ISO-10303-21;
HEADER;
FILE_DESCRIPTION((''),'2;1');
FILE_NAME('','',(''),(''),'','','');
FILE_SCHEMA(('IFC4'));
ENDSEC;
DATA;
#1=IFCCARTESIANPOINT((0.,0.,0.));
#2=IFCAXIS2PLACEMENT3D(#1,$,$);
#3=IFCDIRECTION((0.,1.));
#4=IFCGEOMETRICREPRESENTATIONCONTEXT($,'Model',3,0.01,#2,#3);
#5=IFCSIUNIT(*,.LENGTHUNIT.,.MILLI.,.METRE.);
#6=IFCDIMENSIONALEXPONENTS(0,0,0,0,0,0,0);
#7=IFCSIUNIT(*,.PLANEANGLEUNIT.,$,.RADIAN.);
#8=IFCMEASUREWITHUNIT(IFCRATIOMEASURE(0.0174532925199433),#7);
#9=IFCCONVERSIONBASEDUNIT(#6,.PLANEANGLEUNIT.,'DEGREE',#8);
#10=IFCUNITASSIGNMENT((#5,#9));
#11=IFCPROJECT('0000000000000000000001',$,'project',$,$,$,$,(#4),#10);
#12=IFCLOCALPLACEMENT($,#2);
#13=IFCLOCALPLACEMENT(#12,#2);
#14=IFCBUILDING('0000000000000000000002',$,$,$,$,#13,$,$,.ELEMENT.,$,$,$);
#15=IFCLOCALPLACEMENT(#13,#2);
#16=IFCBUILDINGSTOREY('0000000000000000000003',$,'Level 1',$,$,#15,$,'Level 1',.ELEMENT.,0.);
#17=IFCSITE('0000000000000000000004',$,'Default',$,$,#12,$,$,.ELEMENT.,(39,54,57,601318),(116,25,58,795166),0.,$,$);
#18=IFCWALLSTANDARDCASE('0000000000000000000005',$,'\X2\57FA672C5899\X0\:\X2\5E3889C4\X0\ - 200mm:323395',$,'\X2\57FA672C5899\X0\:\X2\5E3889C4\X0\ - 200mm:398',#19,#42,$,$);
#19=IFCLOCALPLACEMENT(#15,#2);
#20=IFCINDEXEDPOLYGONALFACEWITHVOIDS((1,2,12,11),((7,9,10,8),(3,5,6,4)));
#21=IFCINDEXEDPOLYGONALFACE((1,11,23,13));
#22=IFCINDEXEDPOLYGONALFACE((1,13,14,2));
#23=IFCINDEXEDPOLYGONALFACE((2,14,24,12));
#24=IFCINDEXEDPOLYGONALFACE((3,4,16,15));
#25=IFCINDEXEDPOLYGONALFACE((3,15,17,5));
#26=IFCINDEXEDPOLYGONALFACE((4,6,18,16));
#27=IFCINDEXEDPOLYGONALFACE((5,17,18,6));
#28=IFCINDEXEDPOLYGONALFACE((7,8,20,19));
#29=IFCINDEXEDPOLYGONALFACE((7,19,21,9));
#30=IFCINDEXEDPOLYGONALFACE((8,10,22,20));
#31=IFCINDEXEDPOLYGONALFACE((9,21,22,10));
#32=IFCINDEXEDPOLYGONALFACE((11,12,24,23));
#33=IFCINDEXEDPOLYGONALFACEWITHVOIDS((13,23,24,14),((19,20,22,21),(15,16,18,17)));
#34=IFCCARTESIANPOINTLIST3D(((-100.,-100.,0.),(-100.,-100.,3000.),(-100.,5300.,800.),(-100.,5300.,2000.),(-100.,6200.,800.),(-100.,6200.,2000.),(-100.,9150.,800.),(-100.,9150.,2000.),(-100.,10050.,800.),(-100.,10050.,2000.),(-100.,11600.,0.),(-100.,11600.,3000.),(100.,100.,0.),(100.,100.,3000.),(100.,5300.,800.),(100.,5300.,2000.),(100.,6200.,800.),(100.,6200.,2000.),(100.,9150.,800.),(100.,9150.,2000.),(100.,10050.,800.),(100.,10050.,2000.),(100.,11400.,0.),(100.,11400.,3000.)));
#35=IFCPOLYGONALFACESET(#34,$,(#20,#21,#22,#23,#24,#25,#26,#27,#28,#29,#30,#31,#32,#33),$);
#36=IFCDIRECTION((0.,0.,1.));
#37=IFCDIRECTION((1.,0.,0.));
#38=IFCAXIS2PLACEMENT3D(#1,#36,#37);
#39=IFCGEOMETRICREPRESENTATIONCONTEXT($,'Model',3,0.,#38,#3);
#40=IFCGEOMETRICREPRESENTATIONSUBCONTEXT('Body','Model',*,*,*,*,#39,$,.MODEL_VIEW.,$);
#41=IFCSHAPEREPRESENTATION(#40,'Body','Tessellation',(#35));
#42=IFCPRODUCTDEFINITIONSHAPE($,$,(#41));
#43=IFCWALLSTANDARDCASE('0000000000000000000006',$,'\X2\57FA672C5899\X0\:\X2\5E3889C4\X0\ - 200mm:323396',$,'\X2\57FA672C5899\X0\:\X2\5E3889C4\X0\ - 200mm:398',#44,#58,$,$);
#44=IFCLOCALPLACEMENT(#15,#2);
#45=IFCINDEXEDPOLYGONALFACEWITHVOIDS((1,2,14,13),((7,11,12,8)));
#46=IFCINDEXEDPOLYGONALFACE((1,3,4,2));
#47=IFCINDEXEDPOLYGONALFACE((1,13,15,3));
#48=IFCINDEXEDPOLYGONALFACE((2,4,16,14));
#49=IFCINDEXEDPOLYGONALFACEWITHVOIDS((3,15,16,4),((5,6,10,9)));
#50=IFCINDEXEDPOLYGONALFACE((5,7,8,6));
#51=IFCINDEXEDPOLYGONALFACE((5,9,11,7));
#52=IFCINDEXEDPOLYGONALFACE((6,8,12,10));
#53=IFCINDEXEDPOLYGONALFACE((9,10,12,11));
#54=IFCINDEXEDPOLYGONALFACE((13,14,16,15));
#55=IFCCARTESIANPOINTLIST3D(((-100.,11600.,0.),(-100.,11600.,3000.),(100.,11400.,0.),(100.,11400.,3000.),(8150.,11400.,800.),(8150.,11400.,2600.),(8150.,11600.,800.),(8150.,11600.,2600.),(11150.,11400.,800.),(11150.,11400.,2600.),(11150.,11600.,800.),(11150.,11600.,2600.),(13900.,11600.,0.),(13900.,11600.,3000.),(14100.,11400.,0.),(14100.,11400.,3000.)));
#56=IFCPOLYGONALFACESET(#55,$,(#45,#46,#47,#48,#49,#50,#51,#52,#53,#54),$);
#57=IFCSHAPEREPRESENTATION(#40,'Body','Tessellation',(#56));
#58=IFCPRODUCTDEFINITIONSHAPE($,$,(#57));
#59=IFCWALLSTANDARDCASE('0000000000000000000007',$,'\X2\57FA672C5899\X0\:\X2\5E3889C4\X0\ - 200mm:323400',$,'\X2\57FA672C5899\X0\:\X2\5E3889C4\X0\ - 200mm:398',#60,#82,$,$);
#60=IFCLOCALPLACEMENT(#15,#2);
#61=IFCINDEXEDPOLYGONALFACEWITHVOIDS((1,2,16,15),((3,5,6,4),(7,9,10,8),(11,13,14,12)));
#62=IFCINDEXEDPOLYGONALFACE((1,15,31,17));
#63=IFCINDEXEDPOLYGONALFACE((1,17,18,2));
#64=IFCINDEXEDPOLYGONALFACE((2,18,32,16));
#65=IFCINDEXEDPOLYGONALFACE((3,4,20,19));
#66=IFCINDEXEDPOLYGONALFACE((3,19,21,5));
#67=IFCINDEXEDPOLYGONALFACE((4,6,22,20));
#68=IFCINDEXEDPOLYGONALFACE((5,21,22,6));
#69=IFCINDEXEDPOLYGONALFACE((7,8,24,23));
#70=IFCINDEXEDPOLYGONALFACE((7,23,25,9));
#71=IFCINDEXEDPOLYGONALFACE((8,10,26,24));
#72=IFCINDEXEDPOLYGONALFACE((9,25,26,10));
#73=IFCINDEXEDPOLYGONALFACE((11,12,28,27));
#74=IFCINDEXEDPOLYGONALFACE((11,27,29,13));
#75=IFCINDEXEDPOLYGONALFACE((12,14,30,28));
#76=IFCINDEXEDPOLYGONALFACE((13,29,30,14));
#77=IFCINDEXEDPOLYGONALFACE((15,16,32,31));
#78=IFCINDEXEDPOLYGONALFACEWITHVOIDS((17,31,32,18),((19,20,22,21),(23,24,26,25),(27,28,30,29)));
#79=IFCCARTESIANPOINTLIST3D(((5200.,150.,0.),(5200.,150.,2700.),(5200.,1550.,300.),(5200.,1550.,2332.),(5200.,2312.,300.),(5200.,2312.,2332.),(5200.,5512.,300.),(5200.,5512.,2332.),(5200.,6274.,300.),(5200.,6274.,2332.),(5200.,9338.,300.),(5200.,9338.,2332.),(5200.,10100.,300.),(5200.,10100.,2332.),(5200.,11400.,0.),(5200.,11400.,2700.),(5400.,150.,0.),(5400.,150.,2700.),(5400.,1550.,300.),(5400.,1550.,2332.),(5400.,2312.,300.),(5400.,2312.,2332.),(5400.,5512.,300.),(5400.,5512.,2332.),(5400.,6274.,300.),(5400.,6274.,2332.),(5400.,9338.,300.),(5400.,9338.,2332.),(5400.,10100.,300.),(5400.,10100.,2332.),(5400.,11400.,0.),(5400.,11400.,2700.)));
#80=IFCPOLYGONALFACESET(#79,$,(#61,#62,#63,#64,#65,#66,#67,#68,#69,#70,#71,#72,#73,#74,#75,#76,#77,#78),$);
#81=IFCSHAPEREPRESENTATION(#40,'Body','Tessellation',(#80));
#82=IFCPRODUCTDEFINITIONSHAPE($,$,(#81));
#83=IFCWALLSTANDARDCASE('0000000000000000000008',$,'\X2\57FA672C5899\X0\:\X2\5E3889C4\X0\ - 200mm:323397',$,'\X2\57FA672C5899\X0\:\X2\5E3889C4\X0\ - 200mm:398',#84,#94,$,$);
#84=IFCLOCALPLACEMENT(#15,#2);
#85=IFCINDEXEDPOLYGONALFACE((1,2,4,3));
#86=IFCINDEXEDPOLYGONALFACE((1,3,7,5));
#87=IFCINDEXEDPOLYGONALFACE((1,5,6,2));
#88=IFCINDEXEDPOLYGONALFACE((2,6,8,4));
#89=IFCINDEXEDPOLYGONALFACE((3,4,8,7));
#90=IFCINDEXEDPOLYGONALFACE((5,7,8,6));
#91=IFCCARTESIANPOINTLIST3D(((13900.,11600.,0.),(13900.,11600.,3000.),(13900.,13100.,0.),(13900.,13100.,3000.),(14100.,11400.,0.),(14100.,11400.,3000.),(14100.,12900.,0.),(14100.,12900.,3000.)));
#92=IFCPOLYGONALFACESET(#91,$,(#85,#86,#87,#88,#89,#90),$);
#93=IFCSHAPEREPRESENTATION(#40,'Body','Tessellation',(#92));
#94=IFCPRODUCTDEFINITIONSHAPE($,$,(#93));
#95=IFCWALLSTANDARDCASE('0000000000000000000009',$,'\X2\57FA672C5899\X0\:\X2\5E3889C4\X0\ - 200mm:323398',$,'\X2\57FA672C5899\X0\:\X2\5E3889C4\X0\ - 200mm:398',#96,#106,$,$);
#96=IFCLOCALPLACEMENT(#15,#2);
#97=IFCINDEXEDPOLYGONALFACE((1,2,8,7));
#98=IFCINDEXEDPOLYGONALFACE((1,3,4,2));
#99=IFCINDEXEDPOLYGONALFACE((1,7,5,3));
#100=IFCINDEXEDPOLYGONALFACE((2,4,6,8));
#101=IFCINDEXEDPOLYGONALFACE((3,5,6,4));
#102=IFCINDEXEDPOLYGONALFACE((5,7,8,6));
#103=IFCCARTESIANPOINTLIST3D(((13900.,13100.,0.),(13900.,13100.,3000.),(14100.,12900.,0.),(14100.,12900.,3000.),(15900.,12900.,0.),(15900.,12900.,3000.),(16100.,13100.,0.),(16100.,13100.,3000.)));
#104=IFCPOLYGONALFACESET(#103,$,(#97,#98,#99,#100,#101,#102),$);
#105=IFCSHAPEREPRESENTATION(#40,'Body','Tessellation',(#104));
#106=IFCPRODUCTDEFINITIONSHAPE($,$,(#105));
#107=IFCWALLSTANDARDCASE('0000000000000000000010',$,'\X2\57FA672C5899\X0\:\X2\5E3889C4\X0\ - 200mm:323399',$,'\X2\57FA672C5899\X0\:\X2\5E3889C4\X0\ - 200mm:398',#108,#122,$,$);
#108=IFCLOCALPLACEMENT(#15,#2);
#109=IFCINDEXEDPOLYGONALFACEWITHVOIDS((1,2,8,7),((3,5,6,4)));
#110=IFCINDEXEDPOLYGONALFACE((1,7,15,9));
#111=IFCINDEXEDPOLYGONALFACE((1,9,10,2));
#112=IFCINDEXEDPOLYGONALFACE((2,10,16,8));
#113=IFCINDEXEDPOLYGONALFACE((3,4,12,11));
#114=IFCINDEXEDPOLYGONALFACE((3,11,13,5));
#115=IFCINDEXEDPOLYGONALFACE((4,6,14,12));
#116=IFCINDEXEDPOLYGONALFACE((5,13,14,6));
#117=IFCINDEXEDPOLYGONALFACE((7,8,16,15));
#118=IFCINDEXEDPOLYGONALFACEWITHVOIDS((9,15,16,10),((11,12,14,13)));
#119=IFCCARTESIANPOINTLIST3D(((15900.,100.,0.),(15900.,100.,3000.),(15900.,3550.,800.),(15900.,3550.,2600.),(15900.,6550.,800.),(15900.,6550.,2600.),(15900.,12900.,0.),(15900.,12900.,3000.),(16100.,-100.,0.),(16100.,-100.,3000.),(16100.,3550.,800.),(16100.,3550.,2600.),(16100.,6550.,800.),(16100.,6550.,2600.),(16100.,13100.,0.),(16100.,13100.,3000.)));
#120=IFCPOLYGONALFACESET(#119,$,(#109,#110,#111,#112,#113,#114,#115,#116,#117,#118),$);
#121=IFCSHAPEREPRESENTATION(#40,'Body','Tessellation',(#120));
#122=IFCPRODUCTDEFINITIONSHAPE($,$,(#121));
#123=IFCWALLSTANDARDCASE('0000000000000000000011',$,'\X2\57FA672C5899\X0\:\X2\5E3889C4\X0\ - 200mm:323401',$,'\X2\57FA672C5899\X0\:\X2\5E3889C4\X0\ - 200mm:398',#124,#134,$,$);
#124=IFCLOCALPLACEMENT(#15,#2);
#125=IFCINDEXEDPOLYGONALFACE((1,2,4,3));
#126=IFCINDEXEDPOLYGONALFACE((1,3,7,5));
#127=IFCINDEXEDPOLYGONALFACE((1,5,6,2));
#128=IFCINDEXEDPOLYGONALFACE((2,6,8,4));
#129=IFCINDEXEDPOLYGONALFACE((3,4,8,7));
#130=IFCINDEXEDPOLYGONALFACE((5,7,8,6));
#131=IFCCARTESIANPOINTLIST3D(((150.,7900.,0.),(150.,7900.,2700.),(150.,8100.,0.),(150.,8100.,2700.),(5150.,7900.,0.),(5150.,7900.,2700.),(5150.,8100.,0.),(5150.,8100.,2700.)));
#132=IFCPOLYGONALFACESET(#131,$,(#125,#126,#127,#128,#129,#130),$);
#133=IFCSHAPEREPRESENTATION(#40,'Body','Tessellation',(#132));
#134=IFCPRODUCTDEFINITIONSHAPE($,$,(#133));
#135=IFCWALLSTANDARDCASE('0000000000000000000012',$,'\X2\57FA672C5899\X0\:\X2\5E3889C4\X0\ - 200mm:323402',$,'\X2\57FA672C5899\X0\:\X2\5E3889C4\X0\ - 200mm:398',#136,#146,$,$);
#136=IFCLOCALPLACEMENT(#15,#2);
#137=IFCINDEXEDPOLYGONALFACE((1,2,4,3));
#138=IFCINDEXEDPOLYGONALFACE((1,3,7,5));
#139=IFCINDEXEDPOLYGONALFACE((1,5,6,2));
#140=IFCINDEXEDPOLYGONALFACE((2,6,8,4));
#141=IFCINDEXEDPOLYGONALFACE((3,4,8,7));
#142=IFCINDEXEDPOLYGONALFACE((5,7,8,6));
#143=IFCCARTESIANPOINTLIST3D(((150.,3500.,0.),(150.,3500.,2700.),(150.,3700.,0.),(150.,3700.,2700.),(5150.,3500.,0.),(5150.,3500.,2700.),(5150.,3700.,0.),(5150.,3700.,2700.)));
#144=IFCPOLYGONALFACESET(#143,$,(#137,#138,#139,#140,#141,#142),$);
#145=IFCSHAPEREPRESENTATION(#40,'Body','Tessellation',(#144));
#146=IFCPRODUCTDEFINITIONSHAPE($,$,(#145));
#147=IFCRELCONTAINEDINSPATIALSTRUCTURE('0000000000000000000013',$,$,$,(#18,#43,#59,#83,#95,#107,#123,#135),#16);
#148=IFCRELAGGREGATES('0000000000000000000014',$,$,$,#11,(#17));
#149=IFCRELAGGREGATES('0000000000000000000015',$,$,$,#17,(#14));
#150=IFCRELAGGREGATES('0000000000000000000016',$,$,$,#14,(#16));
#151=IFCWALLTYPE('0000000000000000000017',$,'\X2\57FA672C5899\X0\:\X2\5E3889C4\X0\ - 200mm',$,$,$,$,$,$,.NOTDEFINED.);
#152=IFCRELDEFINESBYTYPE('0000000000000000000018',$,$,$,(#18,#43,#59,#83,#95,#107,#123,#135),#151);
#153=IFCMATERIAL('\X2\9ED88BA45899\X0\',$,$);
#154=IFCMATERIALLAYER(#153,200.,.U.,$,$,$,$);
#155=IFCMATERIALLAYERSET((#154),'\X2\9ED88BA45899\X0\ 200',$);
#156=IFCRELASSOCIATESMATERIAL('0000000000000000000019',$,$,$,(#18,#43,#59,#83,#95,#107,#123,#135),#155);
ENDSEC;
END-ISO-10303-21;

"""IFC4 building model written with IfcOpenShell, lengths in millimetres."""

from ifc_helpers import new_model, entity, si_unit, converted_unit, direction, frame, origin, origin_with_axes, place, context, subcontext, project, spatial, polyline, outline, extrude, clip, halfspace, material, layer, layer_set, layer_usage, type_object, element, save


model = new_model("IFC4")

# Units and contexts
model_context_1 = context("Model", 3, precision=0.01, world=origin(), true_north=direction((0.0, 1.0)))
model_context_2 = context("Model", 3, precision=0.0, world=origin_with_axes(), true_north=direction((0.0, 1.0)))
body_context_1 = subcontext(model_context_2, "Body", "Model", "MODEL_VIEW")
ifc_project = project(units=[si_unit("LENGTHUNIT", "METRE", prefix="MILLI"), converted_unit("PLANEANGLEUNIT", "DEGREE", entity("IfcRatioMeasure", 0.0174532925199433), si_unit("PLANEANGLEUNIT", "RADIAN"), dimensions=[0, 0, 0, 0, 0, 0, 0])], contexts=[model_context_1])

# Site, building, storey
site_placement = place(None, origin())
site = spatial("IfcSite", under=ifc_project, at=site_placement, Name="Default", CompositionType="ELEMENT", RefLatitude=(39, 54, 57, 601318), RefLongitude=(116, 25, 58, 795166), RefElevation=0.0)
building_placement = place(site_placement, origin())
building = spatial("IfcBuilding", under=site, at=building_placement, CompositionType="ELEMENT")
storey_placement = place(building_placement, origin())
storey = spatial("IfcBuildingStorey", under=building, at=storey_placement, Name="Level 1", LongName="Level 1", CompositionType="ELEMENT", Elevation=0.0)

# Shared definitions
placement_1 = place(None, origin_with_axes())
placement_2 = place(placement_1, origin_with_axes())
placement_3 = place(placement_2, origin_with_axes())

# Wall, openings
ifc_material_1 = material(Name="默认墙")
ifc_layer_1 = layer(ifc_material_1, 200.0, ventilated="UNKNOWN")
ifc_layer_set_1 = layer_set([ifc_layer_1], Name="默认墙 200")
wall_type = type_object("IfcWallType", Name="基本墙:常规 - 200mm", PredefinedType="NOTDEFINED")
ifc_layer_usage_1 = layer_usage(ifc_layer_set_1, "AXIS2", "POSITIVE", -100.0)
wall_1_placement = place(placement_3, frame((0.0, 0.0, 0.0), z_axis=(0.0, 0.0, 1.0), x_axis=(0.0, 1.0, 0.0)))
wall_1 = element("IfcWallStandardCase", 1, at=wall_1_placement, inside=storey, type_object=wall_type, material=ifc_layer_usage_1, Name="基本墙:常规 - 200mm:323395", ObjectType="基本墙:常规 - 200mm:398", context=body_context_1, shape_type="SweptSolid", body=[
    extrude(outline(polyline([(100.0, -100.0), (11400.0, -100.0), (11600.0, 100.0), (-100.0, 100.0), (100.0, -100.0)])), origin_with_axes(), (0.0, 0.0, 1.0), 3000.0),
])
opening_1_placement = place(wall_1_placement, frame((5750.0, 0.0, 800.0), z_axis=(0.0, 0.0, 1.0), x_axis=(1.0, 0.0, 0.0)))
element("IfcOpeningElement", 2, at=opening_1_placement, cuts=wall_1, context=body_context_1, shape_type="SweptSolid", body=[
    extrude(outline(polyline([(450.0, -1200.0), (450.0, 0.0), (-450.0, 0.0), (-450.0, -1200.0), (450.0, -1200.0)])), frame((0.0, 100.0, 0.0), z_axis=(0.0, -1.0, 0.0), x_axis=(-1.0, 0.0, 0.0)), (0.0, 0.0, 1.0), 200.0),
])
opening_2_placement = place(wall_1_placement, frame((9600.0, 0.0, 800.0), z_axis=(0.0, 0.0, 1.0), x_axis=(1.0, 0.0, 0.0)))
element("IfcOpeningElement", 3, at=opening_2_placement, cuts=wall_1, context=body_context_1, shape_type="SweptSolid", body=[
    extrude(outline(polyline([(450.0, -1200.0), (450.0, 0.0), (-450.0, 0.0), (-450.0, -1200.0), (450.0, -1200.0)])), frame((0.0, 100.0, 0.0), z_axis=(0.0, -1.0, 0.0), x_axis=(-1.0, 0.0, 0.0)), (0.0, 0.0, 1.0), 200.0),
])

# Wall, opening
ifc_layer_usage_2 = layer_usage(ifc_layer_set_1, "AXIS2", "POSITIVE", -100.0)
wall_2_placement = place(placement_3, frame((0.0, 11500.0, 0.0), z_axis=(0.0, 0.0, 1.0), x_axis=(1.0, 0.0, 0.0)))
wall_2 = element("IfcWallStandardCase", 4, at=wall_2_placement, inside=storey, type_object=wall_type, material=ifc_layer_usage_2, Name="基本墙:常规 - 200mm:323396", ObjectType="基本墙:常规 - 200mm:398", context=body_context_1, shape_type="SweptSolid", body=[
    extrude(outline(polyline([(100.0, -100.0), (14100.0, -100.0), (13900.0, 100.0), (-100.0, 100.0), (100.0, -100.0)])), origin_with_axes(), (0.0, 0.0, 1.0), 3000.0),
])
opening_3_placement = place(wall_2_placement, frame((9650.0, 0.0, 800.0), z_axis=(0.0, 0.0, 1.0), x_axis=(1.0, 0.0, 0.0)))
element("IfcOpeningElement", 5, at=opening_3_placement, cuts=wall_2, context=body_context_1, shape_type="SweptSolid", body=[
    extrude(outline(polyline([(-1500.0, 0.0), (-1500.0, -1800.0), (1500.0, -1800.0), (1500.0, 0.0), (-1500.0, 0.0)])), frame((0.0, -100.0, 0.0), z_axis=(0.0, 1.0, 0.0), x_axis=(1.0, 0.0, 0.0)), (0.0, 0.0, 1.0), 200.0),
])

# Wall, openings
ifc_layer_usage_3 = layer_usage(ifc_layer_set_1, "AXIS2", "POSITIVE", -100.0)
wall_3_placement = place(placement_3, frame((5300.0, 11500.0, 0.0), z_axis=(0.0, 0.0, 1.0), x_axis=(0.0, -1.0, 0.0)))
wall_3 = element("IfcWallStandardCase", 6, at=wall_3_placement, inside=storey, type_object=wall_type, material=ifc_layer_usage_3, Name="基本墙:常规 - 200mm:323400", ObjectType="基本墙:常规 - 200mm:398", context=body_context_1, shape_type="Clipping", body=[
    clip(extrude(outline(polyline([(100.0, -100.0), (11350.0, -100.0), (11350.0, 100.0), (100.0, 100.0), (100.0, -100.0)])), origin_with_axes(), (0.0, 0.0, 1.0), 2700.0), halfspace(frame((0.0, 0.0, 2700.0), z_axis=(0.0, 0.0, -1.0), x_axis=(0.0, 1.0, 0.0)), True)),
])
opening_4_placement = place(wall_3_placement, frame((9569.0, 0.0, 300.0), z_axis=(0.0, 0.0, 1.0), x_axis=(1.0, 0.0, 0.0)))
element("IfcOpeningElement", 7, at=opening_4_placement, cuts=wall_3, context=body_context_1, shape_type="SweptSolid", body=[
    extrude(outline(polyline([(-381.0, -2032.0), (381.0, -2032.0), (381.0, 0.0), (-381.0, 0.0), (-381.0, -2032.0)])), frame((0.0, -100.0, 0.0), z_axis=(0.0, 1.0, 0.0), x_axis=(1.0, 0.0, 0.0)), (0.0, 0.0, 1.0), 200.0),
])
opening_5_placement = place(wall_3_placement, frame((5607.0, 0.0, 300.0), z_axis=(0.0, 0.0, 1.0), x_axis=(1.0, 0.0, 0.0)))
element("IfcOpeningElement", 8, at=opening_5_placement, cuts=wall_3, context=body_context_1, shape_type="SweptSolid", body=[
    extrude(outline(polyline([(-381.0, -2032.0), (381.0, -2032.0), (381.0, 0.0), (-381.0, 0.0), (-381.0, -2032.0)])), frame((0.0, -100.0, 0.0), z_axis=(0.0, 1.0, 0.0), x_axis=(1.0, 0.0, 0.0)), (0.0, 0.0, 1.0), 200.0),
])
opening_6_placement = place(wall_3_placement, frame((1781.0, 0.0, 300.0), z_axis=(0.0, 0.0, 1.0), x_axis=(1.0, 0.0, 0.0)))
element("IfcOpeningElement", 9, at=opening_6_placement, cuts=wall_3, context=body_context_1, shape_type="SweptSolid", body=[
    extrude(outline(polyline([(-381.0, -2032.0), (381.0, -2032.0), (381.0, 0.0), (-381.0, 0.0), (-381.0, -2032.0)])), frame((0.0, -100.0, 0.0), z_axis=(0.0, 1.0, 0.0), x_axis=(1.0, 0.0, 0.0)), (0.0, 0.0, 1.0), 200.0),
])

# Walls
ifc_layer_usage_4 = layer_usage(ifc_layer_set_1, "AXIS2", "POSITIVE", -100.0)
wall_4_placement = place(placement_3, frame((14000.0, 11500.0, 0.0), z_axis=(0.0, 0.0, 1.0), x_axis=(0.0, 1.0, 0.0)))
element("IfcWallStandardCase", 10, at=wall_4_placement, inside=storey, type_object=wall_type, material=ifc_layer_usage_4, Name="基本墙:常规 - 200mm:323397", ObjectType="基本墙:常规 - 200mm:398", context=body_context_1, shape_type="SweptSolid", body=[
    extrude(outline(polyline([(-100.0, -100.0), (1400.0, -100.0), (1600.0, 100.0), (100.0, 100.0), (-100.0, -100.0)])), origin_with_axes(), (0.0, 0.0, 1.0), 3000.0),
])
ifc_layer_usage_5 = layer_usage(ifc_layer_set_1, "AXIS2", "POSITIVE", -100.0)
wall_5_placement = place(placement_3, frame((14000.0, 13000.0, 0.0), z_axis=(0.0, 0.0, 1.0), x_axis=(1.0, 0.0, 0.0)))
element("IfcWallStandardCase", 11, at=wall_5_placement, inside=storey, type_object=wall_type, material=ifc_layer_usage_5, Name="基本墙:常规 - 200mm:323398", ObjectType="基本墙:常规 - 200mm:398", context=body_context_1, shape_type="SweptSolid", body=[
    extrude(outline(polyline([(100.0, -100.0), (1900.0, -100.0), (2100.0, 100.0), (-100.0, 100.0), (100.0, -100.0)])), origin_with_axes(), (0.0, 0.0, 1.0), 3000.0),
])

# Wall, opening
ifc_layer_usage_6 = layer_usage(ifc_layer_set_1, "AXIS2", "POSITIVE", -100.0)
wall_6_placement = place(placement_3, frame((16000.0, 13000.0, 0.0), z_axis=(0.0, 0.0, 1.0), x_axis=(0.0, -1.0, 0.0)))
wall_6 = element("IfcWallStandardCase", 12, at=wall_6_placement, inside=storey, type_object=wall_type, material=ifc_layer_usage_6, Name="基本墙:常规 - 200mm:323399", ObjectType="基本墙:常规 - 200mm:398", context=body_context_1, shape_type="SweptSolid", body=[
    extrude(outline(polyline([(100.0, -100.0), (12900.0, -100.0), (13100.0, 100.0), (-100.0, 100.0), (100.0, -100.0)])), origin_with_axes(), (0.0, 0.0, 1.0), 3000.0),
])
opening_7_placement = place(wall_6_placement, frame((7950.0, 0.0, 800.0), z_axis=(0.0, 0.0, 1.0), x_axis=(1.0, 0.0, 0.0)))
element("IfcOpeningElement", 13, at=opening_7_placement, cuts=wall_6, context=body_context_1, shape_type="SweptSolid", body=[
    extrude(outline(polyline([(-1500.0, 0.0), (-1500.0, -1800.0), (1500.0, -1800.0), (1500.0, 0.0), (-1500.0, 0.0)])), frame((0.0, -100.0, 0.0), z_axis=(0.0, 1.0, 0.0), x_axis=(1.0, 0.0, 0.0)), (0.0, 0.0, 1.0), 200.0),
])

# Walls
ifc_layer_usage_7 = layer_usage(ifc_layer_set_1, "AXIS2", "POSITIVE", -100.0)
wall_7_placement = place(placement_3, frame((150.0, 8000.0, 0.0), z_axis=(0.0, 0.0, 1.0), x_axis=(1.0, 0.0, 0.0)))
element("IfcWallStandardCase", 14, at=wall_7_placement, inside=storey, type_object=wall_type, material=ifc_layer_usage_7, Name="基本墙:常规 - 200mm:323401", ObjectType="基本墙:常规 - 200mm:398", context=body_context_1, shape_type="Clipping", body=[
    clip(extrude(outline(polyline([(0.0, -100.0), (5000.0, -100.0), (5000.0, 100.0), (0.0, 100.0), (0.0, -100.0)])), origin_with_axes(), (0.0, 0.0, 1.0), 2700.0), halfspace(frame((0.0, 0.0, 2700.0), z_axis=(0.0, 0.0, -1.0), x_axis=(0.0, 1.0, 0.0)), True)),
])
ifc_layer_usage_8 = layer_usage(ifc_layer_set_1, "AXIS2", "POSITIVE", -100.0)
wall_8_placement = place(placement_3, frame((150.0, 3600.0, 0.0), z_axis=(0.0, 0.0, 1.0), x_axis=(1.0, 0.0, 0.0)))
element("IfcWallStandardCase", 15, at=wall_8_placement, inside=storey, type_object=wall_type, material=ifc_layer_usage_8, Name="基本墙:常规 - 200mm:323402", ObjectType="基本墙:常规 - 200mm:398", context=body_context_1, shape_type="Clipping", body=[
    clip(extrude(outline(polyline([(0.0, -100.0), (5000.0, -100.0), (5000.0, 100.0), (0.0, 100.0), (0.0, -100.0)])), origin_with_axes(), (0.0, 0.0, 1.0), 2700.0), halfspace(frame((0.0, 0.0, 2700.0), z_axis=(0.0, 0.0, -1.0), x_axis=(0.0, 1.0, 0.0)), True)),
])

save(model, "model.ifc")
